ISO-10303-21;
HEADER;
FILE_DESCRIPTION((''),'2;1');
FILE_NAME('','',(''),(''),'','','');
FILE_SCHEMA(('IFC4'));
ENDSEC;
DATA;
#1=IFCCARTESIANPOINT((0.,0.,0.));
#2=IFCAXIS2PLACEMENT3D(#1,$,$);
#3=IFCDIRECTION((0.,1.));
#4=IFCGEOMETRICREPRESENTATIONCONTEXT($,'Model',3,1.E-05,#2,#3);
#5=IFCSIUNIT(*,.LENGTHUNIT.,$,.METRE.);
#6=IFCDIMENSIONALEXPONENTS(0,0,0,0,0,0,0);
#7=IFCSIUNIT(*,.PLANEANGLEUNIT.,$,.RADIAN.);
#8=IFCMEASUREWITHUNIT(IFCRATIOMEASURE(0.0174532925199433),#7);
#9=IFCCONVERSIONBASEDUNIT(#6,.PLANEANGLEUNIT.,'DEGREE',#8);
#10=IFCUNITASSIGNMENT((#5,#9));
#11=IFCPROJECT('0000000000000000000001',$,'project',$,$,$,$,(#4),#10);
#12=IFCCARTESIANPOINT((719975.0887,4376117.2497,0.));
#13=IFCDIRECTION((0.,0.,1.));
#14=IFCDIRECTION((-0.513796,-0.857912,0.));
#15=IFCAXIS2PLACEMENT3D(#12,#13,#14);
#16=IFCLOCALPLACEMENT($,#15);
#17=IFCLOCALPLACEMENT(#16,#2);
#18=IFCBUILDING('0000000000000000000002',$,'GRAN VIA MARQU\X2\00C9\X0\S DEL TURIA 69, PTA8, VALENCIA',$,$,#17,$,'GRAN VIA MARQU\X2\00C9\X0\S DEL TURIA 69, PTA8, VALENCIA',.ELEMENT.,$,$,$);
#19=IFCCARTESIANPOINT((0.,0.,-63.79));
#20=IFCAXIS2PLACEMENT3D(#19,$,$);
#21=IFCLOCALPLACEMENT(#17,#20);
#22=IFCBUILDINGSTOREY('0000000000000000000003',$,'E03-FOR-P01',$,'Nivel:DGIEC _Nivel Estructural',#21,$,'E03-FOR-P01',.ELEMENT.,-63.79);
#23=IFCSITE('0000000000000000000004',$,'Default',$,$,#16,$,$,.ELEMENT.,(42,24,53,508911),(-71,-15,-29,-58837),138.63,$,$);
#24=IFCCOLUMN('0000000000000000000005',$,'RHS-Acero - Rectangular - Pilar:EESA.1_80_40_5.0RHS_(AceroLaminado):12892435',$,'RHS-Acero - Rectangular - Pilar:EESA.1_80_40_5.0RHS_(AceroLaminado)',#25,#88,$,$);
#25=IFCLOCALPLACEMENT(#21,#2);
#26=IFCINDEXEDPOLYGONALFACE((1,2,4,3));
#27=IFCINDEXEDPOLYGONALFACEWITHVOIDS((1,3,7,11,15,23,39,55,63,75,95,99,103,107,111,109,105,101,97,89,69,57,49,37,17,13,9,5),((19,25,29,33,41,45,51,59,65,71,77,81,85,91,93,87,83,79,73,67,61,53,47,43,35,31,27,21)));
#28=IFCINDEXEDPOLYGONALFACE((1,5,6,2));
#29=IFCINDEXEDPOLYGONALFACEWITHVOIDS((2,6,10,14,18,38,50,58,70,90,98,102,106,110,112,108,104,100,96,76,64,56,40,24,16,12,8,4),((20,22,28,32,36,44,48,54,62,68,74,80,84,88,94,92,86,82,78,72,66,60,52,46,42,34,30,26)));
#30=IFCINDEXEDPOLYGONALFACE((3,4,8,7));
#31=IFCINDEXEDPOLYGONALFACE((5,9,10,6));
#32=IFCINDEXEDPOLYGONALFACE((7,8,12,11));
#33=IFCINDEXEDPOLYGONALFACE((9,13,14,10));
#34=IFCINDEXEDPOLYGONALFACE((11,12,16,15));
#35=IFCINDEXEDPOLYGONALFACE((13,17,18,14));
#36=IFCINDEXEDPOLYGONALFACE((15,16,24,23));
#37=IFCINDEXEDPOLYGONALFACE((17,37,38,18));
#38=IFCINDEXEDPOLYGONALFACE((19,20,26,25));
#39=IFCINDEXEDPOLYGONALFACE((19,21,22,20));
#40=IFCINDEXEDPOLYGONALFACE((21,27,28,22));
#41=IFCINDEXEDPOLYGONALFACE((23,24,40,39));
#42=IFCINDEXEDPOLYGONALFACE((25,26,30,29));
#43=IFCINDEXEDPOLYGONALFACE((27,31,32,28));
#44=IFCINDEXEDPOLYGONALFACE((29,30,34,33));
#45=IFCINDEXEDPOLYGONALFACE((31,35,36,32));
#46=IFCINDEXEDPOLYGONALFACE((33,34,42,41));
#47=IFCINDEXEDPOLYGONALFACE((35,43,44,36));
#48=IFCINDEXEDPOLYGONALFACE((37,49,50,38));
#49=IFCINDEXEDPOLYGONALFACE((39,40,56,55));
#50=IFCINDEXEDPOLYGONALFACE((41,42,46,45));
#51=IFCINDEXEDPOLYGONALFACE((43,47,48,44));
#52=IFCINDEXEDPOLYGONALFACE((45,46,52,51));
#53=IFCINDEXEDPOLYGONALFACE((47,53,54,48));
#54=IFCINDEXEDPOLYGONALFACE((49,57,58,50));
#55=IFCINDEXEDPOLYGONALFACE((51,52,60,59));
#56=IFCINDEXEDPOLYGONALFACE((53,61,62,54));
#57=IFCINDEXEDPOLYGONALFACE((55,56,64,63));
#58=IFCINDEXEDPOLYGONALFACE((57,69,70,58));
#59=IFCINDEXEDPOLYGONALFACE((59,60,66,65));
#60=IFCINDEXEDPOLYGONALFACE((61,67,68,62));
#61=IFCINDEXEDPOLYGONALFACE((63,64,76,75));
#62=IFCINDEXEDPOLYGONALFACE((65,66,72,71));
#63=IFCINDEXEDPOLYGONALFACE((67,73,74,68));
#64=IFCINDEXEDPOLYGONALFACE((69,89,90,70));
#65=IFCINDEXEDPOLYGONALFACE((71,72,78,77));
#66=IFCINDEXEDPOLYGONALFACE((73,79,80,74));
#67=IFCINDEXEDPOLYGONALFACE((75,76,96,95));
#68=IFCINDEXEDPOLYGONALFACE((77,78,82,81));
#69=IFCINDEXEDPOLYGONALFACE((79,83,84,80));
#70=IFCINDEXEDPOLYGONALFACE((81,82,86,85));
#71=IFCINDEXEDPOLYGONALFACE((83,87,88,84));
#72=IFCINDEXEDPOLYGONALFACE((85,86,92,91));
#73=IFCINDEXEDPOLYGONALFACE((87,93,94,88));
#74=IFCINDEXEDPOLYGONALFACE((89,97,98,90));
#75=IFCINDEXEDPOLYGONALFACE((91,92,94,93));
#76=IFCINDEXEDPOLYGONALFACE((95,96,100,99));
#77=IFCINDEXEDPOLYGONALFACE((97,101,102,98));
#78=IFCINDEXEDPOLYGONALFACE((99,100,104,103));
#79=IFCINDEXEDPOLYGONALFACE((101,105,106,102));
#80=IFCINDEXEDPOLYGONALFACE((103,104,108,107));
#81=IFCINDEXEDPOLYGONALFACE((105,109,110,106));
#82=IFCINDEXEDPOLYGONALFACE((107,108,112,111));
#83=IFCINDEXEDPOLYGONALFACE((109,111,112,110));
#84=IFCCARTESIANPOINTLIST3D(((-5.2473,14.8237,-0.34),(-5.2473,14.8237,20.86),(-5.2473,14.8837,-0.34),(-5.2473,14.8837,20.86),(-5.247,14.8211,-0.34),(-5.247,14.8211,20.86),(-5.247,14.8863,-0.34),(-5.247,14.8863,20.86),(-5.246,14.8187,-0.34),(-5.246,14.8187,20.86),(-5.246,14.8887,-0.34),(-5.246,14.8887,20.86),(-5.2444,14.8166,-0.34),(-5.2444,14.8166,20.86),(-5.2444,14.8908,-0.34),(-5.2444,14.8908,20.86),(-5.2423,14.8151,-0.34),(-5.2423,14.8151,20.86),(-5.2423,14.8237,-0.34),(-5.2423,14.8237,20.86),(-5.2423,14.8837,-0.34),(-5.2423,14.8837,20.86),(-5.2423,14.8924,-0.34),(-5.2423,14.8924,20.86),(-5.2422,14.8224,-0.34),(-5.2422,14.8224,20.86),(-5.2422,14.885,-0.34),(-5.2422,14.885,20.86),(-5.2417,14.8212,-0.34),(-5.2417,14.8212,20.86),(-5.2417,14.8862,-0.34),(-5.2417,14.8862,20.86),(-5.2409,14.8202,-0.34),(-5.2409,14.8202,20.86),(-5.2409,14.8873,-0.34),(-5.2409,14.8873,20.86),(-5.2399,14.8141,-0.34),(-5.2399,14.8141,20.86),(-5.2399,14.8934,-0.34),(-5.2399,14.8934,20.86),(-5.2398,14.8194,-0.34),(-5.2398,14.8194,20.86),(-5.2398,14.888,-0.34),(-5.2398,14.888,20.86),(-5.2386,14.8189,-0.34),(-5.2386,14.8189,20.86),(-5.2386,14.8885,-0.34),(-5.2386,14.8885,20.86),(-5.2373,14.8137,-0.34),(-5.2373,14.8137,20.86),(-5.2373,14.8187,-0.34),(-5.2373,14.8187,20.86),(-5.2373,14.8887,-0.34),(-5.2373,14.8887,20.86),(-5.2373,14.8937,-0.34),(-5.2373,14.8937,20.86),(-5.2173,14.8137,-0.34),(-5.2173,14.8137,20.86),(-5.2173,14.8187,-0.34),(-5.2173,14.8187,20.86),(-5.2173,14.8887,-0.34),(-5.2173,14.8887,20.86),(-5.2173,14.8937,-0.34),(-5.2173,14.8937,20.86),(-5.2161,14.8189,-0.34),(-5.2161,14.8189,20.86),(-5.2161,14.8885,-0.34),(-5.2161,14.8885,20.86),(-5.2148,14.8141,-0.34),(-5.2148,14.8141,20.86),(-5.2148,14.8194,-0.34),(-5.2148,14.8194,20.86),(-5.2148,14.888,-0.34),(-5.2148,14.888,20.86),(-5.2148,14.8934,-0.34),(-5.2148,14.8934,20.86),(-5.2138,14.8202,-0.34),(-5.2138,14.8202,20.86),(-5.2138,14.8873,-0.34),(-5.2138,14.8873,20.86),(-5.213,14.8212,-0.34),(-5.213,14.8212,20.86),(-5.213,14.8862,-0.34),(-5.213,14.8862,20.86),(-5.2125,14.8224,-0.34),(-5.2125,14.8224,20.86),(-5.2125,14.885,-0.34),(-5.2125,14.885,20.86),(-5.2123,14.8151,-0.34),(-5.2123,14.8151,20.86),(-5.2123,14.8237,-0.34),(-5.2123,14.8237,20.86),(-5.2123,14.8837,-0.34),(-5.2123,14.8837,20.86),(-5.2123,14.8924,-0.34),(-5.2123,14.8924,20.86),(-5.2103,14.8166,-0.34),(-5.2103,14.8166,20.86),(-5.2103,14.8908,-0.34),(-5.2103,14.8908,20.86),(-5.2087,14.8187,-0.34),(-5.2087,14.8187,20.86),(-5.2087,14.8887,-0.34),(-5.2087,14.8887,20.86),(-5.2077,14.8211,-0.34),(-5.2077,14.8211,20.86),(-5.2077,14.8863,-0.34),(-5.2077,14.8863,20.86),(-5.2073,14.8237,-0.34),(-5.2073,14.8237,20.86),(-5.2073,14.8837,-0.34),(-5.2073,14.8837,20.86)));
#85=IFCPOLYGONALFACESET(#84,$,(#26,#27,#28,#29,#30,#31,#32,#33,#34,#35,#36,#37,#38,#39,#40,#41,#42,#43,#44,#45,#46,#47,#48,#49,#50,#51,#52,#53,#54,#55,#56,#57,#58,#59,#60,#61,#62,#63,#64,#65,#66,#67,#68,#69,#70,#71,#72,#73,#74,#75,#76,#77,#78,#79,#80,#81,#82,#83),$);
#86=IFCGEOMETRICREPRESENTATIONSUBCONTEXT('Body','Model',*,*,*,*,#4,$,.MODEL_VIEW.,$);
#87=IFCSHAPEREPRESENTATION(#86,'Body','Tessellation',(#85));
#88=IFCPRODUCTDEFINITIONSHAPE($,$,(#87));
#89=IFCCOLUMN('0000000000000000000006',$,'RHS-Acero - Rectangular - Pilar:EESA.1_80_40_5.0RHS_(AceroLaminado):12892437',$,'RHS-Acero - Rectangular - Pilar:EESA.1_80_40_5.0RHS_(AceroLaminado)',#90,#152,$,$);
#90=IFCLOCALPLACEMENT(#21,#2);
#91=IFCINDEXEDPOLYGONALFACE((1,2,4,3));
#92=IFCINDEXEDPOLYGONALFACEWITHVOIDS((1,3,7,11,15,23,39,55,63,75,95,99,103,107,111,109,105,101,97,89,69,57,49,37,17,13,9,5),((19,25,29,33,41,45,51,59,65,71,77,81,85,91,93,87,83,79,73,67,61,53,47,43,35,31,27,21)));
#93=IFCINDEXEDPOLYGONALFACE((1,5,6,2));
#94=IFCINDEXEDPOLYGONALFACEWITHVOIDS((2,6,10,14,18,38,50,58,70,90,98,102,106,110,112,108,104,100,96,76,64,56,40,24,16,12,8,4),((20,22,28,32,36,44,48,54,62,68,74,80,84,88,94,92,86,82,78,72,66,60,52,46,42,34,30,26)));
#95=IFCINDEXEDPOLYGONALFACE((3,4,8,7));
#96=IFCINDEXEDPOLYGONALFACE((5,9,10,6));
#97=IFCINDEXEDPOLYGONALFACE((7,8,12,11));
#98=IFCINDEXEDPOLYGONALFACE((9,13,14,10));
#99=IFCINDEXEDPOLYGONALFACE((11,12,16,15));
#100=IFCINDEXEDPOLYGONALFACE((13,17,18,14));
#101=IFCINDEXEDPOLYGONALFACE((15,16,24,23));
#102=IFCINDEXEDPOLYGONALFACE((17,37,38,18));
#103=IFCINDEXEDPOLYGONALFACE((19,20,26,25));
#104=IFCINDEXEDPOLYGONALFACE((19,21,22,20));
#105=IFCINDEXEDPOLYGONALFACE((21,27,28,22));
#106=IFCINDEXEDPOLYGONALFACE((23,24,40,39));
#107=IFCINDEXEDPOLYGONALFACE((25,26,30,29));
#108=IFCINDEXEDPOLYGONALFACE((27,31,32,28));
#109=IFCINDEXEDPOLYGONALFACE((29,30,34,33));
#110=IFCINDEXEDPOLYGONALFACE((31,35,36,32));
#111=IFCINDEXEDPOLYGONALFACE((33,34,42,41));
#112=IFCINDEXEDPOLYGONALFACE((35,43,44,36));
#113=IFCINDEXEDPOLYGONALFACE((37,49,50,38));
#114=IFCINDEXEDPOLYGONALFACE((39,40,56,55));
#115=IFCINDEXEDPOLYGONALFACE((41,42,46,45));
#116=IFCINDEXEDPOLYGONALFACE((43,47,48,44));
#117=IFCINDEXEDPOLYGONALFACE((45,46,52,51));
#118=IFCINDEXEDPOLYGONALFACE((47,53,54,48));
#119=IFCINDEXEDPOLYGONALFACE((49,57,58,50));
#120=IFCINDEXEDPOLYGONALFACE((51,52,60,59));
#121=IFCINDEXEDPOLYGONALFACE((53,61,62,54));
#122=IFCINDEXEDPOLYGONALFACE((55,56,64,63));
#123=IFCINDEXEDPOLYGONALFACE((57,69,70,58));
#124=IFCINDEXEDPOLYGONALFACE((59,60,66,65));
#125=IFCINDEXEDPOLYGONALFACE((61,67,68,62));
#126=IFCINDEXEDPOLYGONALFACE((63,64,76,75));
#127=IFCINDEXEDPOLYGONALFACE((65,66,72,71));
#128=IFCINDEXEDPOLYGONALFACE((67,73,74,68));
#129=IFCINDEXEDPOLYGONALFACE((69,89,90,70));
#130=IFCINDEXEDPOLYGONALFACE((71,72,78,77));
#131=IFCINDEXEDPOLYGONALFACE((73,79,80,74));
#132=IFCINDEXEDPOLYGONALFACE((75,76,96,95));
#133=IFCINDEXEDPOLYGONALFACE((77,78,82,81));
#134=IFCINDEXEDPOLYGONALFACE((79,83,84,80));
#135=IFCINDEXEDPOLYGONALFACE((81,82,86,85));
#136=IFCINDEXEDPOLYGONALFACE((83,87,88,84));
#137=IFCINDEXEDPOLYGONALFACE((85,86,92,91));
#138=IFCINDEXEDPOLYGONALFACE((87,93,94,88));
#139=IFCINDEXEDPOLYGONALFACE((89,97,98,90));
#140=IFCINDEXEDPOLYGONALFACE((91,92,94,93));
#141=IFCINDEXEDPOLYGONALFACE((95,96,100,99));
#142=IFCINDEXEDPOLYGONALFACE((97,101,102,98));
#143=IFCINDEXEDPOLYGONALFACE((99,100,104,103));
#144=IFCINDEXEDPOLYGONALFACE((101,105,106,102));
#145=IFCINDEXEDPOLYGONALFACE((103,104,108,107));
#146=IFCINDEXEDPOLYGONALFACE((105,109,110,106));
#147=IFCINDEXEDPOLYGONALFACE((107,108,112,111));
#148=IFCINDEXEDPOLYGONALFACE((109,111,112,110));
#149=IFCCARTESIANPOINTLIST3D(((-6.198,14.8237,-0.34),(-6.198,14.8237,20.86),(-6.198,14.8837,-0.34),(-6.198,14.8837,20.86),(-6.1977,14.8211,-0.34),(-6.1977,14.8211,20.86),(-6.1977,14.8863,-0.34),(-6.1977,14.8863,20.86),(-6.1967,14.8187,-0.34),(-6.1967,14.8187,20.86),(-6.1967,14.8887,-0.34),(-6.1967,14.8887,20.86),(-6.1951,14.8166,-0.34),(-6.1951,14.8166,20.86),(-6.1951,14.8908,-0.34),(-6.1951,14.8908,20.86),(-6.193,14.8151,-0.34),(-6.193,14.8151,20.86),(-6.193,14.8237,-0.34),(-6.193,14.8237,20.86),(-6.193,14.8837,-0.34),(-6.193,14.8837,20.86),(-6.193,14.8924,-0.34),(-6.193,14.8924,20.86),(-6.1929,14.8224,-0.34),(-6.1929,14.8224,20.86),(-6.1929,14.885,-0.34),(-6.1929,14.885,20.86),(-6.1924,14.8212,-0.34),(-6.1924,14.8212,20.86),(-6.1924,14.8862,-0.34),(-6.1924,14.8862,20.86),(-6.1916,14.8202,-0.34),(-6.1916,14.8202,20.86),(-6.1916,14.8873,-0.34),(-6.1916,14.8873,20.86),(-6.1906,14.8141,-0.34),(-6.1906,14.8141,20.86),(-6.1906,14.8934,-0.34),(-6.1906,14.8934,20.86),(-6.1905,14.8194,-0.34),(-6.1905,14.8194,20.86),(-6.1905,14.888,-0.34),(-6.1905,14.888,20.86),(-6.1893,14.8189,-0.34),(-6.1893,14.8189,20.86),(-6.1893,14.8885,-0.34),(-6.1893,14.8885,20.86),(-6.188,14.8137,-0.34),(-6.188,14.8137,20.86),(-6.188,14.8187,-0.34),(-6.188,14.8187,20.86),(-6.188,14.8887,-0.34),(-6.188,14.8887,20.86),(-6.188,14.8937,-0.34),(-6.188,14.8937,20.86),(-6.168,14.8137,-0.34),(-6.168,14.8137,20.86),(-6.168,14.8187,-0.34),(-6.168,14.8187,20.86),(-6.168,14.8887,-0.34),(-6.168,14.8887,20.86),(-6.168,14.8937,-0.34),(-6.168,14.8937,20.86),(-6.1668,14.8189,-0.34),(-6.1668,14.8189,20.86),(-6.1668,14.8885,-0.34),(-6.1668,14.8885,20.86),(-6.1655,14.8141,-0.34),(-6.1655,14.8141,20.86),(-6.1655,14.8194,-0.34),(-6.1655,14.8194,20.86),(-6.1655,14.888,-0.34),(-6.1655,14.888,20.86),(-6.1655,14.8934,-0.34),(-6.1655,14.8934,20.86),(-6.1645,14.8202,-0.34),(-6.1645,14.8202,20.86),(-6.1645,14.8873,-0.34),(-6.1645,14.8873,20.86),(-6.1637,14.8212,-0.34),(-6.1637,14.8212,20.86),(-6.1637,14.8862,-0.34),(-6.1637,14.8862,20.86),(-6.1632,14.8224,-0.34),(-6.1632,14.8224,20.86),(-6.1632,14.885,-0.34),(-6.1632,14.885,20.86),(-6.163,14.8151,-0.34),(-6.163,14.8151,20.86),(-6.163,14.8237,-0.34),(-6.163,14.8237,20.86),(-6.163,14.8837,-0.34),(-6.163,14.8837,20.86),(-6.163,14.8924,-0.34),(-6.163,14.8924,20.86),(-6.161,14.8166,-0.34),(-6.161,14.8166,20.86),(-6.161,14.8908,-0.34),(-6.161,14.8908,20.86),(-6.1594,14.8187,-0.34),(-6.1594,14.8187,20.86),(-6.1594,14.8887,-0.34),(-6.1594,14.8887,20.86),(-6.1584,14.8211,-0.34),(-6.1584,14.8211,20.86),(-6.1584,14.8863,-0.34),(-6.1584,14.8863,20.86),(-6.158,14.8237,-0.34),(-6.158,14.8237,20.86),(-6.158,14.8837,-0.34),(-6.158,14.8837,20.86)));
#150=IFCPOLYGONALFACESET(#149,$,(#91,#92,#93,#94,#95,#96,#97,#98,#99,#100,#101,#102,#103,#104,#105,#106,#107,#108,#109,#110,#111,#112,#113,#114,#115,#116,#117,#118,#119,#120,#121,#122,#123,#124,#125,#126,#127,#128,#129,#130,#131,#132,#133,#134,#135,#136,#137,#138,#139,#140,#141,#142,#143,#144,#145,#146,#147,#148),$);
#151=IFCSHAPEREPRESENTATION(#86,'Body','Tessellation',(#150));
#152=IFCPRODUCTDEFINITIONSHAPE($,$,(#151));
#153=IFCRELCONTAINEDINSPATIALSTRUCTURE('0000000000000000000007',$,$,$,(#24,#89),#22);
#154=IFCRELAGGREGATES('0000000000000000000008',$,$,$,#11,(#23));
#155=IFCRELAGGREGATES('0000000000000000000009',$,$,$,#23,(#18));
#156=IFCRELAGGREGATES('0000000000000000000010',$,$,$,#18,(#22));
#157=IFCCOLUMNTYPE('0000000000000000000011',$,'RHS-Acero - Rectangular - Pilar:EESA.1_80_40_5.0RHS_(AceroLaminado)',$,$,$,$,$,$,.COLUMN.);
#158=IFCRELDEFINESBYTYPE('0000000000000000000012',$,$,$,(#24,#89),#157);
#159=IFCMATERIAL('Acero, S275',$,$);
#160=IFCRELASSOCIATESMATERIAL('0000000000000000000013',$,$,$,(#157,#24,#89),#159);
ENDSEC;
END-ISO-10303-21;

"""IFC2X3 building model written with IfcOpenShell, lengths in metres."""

from ifc_helpers import new_model, entity, si_unit, converted_unit, direction, frame, frame_2d, origin, place, context, subcontext, project, spatial, polyline, circle_curve, parameter, trimmed, segment, composite_curve, outline, extrude, source, transform, mapped, material, type_object, type_shapes, element, save


model = new_model("IFC2X3")

# Units and contexts
model_context = context("Model", 3, precision=1e-05, world=origin(), true_north=direction((0.0, 1.0)))
body_context = subcontext(model_context, "Body", "Model", "MODEL_VIEW")
ifc_project = project(units=[si_unit("LENGTHUNIT", "METRE"), converted_unit("PLANEANGLEUNIT", "DEGREE", entity("IfcRatioMeasure", 0.0174532925199433), si_unit("PLANEANGLEUNIT", "RADIAN"), dimensions=[0, 0, 0, 0, 0, 0, 0])], contexts=[model_context])

# Site, building, storey
site_placement = place(None, frame((719975.0887, 4376117.2497, 0.0), z_axis=(0.0, 0.0, 1.0), x_axis=(-0.513796, -0.857912, 0.0)))
site = spatial("IfcSite", under=ifc_project, at=site_placement, Name="Default", CompositionType="ELEMENT", RefLatitude=(42, 24, 53, 508911), RefLongitude=(-71, -15, -29, -58837), RefElevation=138.63)
building_placement = place(site_placement, origin())
building = spatial("IfcBuilding", under=site, at=building_placement, Name="GRAN VIA MARQUÉS DEL TURIA 69, PTA8, VALENCIA", LongName="GRAN VIA MARQUÉS DEL TURIA 69, PTA8, VALENCIA", CompositionType="ELEMENT")
storey_placement = place(building_placement, frame((0.0, 0.0, -63.79)))
storey = spatial("IfcBuildingStorey", under=building, at=storey_placement, Name="E03-FOR-P01", ObjectType="Nivel:DGIEC _Nivel Estructural", LongName="E03-FOR-P01", CompositionType="ELEMENT", Elevation=-63.79)

# Columns
ifc_material_1 = material(Name="Acero, S275")
column_type_1 = type_object("IfcColumnType", Name="RHS-Acero - Rectangular - Pilar:EESA.1_80_40_5.0RHS_(AceroLaminado)", PredefinedType="COLUMN", material=ifc_material_1)
shared_shape_1 = source(origin(), body_context, "Body", "SweptSolid", [
    extrude(outline(composite_curve([segment(polyline([(-0.01, -0.04), (0.01, -0.04)]), True, "CONTINUOUS"), segment(trimmed(circle_curve(frame_2d((0.01, -0.03), x_axis=(-1.0, 0.0)), 0.01), [parameter(90.0)], [parameter(180.0)], True, "PARAMETER"), True, "CONTINUOUS"), segment(polyline([(0.02, -0.03), (0.02, 0.03)]), True, "CONTINUOUS"), segment(trimmed(circle_curve(frame_2d((0.01, 0.03), x_axis=(-1.0, 0.0)), 0.01), [parameter(180.0)], [parameter(270.0)], True, "PARAMETER"), True, "CONTINUOUS"), segment(polyline([(0.01, 0.04), (-0.01, 0.04)]), True, "CONTINUOUS"), segment(trimmed(circle_curve(frame_2d((-0.01, 0.03), x_axis=(-1.0, 0.0)), 0.01), [parameter(270.0)], [parameter(360.0)], True, "PARAMETER"), True, "CONTINUOUS"), segment(polyline([(-0.02, 0.03), (-0.02, -0.03)]), True, "CONTINUOUS"), segment(trimmed(circle_curve(frame_2d((-0.01, -0.03), x_axis=(-1.0, 0.0)), 0.01), [parameter(360.0)], [parameter(90.0)], True, "PARAMETER"), True, "CONTINUOUS")], self_intersect=False), holes=[composite_curve([segment(trimmed(circle_curve(frame_2d((-0.01, -0.03), x_axis=(-1.0, 0.0)), 0.005), [parameter(0.0)], [parameter(90.0)], True, "PARAMETER"), False, "CONTINUOUS"), segment(polyline([(-0.015, -0.03), (-0.015, 0.03)]), True, "CONTINUOUS"), segment(trimmed(circle_curve(frame_2d((-0.01, 0.03), x_axis=(-1.0, 0.0)), 0.005), [parameter(270.0)], [parameter(0.0)], True, "PARAMETER"), False, "CONTINUOUS"), segment(polyline([(-0.01, 0.035), (0.01, 0.035)]), True, "CONTINUOUS"), segment(trimmed(circle_curve(frame_2d((0.01, 0.03), x_axis=(-1.0, 0.0)), 0.005), [parameter(180.0)], [parameter(270.0)], True, "PARAMETER"), False, "CONTINUOUS"), segment(polyline([(0.015, 0.03), (0.015, -0.03)]), True, "CONTINUOUS"), segment(trimmed(circle_curve(frame_2d((0.01, -0.03), x_axis=(-1.0, 0.0)), 0.005), [parameter(90.0)], [parameter(180.0)], True, "PARAMETER"), False, "CONTINUOUS"), segment(polyline([(0.01, -0.035), (-0.01, -0.035)]), True, "CONTINUOUS")], self_intersect=False)]), frame((0.0, 0.0, -64.13), z_axis=(0.0, 0.0, 1.0), x_axis=(-1.0, 0.0, 0.0)), (0.0, 0.0, 1.0), 21.2),
])
type_shapes(column_type_1, [shared_shape_1])
for number, where, z_axis, x_axis, name in (
    (1, (-5.2273, 14.8537, 63.79), (0.0, 0.0, 1.0), (-1.0, 0.0, 0.0), "RHS-Acero - Rectangular - Pilar:EESA.1_80_40_5.0RHS_(AceroLaminado):12892435"),
    (2, (-6.178, 14.8537, 63.79), (0.0, 0.0, 1.0), (-1.0, 0.0, 0.0), "RHS-Acero - Rectangular - Pilar:EESA.1_80_40_5.0RHS_(AceroLaminado):12892437"),
):
    element("IfcColumn", number, at=place(storey_placement, frame(where, z_axis=z_axis, x_axis=x_axis)), inside=storey, type_object=column_type_1, material=ifc_material_1, Name=name, ObjectType="RHS-Acero - Rectangular - Pilar:EESA.1_80_40_5.0RHS_(AceroLaminado)", context=body_context, shape_type="MappedRepresentation", body=[
        mapped(shared_shape_1, transform((0.0, 0.0, 0.0), scale=1.0)),
    ])

save(model, "model.ifc")
